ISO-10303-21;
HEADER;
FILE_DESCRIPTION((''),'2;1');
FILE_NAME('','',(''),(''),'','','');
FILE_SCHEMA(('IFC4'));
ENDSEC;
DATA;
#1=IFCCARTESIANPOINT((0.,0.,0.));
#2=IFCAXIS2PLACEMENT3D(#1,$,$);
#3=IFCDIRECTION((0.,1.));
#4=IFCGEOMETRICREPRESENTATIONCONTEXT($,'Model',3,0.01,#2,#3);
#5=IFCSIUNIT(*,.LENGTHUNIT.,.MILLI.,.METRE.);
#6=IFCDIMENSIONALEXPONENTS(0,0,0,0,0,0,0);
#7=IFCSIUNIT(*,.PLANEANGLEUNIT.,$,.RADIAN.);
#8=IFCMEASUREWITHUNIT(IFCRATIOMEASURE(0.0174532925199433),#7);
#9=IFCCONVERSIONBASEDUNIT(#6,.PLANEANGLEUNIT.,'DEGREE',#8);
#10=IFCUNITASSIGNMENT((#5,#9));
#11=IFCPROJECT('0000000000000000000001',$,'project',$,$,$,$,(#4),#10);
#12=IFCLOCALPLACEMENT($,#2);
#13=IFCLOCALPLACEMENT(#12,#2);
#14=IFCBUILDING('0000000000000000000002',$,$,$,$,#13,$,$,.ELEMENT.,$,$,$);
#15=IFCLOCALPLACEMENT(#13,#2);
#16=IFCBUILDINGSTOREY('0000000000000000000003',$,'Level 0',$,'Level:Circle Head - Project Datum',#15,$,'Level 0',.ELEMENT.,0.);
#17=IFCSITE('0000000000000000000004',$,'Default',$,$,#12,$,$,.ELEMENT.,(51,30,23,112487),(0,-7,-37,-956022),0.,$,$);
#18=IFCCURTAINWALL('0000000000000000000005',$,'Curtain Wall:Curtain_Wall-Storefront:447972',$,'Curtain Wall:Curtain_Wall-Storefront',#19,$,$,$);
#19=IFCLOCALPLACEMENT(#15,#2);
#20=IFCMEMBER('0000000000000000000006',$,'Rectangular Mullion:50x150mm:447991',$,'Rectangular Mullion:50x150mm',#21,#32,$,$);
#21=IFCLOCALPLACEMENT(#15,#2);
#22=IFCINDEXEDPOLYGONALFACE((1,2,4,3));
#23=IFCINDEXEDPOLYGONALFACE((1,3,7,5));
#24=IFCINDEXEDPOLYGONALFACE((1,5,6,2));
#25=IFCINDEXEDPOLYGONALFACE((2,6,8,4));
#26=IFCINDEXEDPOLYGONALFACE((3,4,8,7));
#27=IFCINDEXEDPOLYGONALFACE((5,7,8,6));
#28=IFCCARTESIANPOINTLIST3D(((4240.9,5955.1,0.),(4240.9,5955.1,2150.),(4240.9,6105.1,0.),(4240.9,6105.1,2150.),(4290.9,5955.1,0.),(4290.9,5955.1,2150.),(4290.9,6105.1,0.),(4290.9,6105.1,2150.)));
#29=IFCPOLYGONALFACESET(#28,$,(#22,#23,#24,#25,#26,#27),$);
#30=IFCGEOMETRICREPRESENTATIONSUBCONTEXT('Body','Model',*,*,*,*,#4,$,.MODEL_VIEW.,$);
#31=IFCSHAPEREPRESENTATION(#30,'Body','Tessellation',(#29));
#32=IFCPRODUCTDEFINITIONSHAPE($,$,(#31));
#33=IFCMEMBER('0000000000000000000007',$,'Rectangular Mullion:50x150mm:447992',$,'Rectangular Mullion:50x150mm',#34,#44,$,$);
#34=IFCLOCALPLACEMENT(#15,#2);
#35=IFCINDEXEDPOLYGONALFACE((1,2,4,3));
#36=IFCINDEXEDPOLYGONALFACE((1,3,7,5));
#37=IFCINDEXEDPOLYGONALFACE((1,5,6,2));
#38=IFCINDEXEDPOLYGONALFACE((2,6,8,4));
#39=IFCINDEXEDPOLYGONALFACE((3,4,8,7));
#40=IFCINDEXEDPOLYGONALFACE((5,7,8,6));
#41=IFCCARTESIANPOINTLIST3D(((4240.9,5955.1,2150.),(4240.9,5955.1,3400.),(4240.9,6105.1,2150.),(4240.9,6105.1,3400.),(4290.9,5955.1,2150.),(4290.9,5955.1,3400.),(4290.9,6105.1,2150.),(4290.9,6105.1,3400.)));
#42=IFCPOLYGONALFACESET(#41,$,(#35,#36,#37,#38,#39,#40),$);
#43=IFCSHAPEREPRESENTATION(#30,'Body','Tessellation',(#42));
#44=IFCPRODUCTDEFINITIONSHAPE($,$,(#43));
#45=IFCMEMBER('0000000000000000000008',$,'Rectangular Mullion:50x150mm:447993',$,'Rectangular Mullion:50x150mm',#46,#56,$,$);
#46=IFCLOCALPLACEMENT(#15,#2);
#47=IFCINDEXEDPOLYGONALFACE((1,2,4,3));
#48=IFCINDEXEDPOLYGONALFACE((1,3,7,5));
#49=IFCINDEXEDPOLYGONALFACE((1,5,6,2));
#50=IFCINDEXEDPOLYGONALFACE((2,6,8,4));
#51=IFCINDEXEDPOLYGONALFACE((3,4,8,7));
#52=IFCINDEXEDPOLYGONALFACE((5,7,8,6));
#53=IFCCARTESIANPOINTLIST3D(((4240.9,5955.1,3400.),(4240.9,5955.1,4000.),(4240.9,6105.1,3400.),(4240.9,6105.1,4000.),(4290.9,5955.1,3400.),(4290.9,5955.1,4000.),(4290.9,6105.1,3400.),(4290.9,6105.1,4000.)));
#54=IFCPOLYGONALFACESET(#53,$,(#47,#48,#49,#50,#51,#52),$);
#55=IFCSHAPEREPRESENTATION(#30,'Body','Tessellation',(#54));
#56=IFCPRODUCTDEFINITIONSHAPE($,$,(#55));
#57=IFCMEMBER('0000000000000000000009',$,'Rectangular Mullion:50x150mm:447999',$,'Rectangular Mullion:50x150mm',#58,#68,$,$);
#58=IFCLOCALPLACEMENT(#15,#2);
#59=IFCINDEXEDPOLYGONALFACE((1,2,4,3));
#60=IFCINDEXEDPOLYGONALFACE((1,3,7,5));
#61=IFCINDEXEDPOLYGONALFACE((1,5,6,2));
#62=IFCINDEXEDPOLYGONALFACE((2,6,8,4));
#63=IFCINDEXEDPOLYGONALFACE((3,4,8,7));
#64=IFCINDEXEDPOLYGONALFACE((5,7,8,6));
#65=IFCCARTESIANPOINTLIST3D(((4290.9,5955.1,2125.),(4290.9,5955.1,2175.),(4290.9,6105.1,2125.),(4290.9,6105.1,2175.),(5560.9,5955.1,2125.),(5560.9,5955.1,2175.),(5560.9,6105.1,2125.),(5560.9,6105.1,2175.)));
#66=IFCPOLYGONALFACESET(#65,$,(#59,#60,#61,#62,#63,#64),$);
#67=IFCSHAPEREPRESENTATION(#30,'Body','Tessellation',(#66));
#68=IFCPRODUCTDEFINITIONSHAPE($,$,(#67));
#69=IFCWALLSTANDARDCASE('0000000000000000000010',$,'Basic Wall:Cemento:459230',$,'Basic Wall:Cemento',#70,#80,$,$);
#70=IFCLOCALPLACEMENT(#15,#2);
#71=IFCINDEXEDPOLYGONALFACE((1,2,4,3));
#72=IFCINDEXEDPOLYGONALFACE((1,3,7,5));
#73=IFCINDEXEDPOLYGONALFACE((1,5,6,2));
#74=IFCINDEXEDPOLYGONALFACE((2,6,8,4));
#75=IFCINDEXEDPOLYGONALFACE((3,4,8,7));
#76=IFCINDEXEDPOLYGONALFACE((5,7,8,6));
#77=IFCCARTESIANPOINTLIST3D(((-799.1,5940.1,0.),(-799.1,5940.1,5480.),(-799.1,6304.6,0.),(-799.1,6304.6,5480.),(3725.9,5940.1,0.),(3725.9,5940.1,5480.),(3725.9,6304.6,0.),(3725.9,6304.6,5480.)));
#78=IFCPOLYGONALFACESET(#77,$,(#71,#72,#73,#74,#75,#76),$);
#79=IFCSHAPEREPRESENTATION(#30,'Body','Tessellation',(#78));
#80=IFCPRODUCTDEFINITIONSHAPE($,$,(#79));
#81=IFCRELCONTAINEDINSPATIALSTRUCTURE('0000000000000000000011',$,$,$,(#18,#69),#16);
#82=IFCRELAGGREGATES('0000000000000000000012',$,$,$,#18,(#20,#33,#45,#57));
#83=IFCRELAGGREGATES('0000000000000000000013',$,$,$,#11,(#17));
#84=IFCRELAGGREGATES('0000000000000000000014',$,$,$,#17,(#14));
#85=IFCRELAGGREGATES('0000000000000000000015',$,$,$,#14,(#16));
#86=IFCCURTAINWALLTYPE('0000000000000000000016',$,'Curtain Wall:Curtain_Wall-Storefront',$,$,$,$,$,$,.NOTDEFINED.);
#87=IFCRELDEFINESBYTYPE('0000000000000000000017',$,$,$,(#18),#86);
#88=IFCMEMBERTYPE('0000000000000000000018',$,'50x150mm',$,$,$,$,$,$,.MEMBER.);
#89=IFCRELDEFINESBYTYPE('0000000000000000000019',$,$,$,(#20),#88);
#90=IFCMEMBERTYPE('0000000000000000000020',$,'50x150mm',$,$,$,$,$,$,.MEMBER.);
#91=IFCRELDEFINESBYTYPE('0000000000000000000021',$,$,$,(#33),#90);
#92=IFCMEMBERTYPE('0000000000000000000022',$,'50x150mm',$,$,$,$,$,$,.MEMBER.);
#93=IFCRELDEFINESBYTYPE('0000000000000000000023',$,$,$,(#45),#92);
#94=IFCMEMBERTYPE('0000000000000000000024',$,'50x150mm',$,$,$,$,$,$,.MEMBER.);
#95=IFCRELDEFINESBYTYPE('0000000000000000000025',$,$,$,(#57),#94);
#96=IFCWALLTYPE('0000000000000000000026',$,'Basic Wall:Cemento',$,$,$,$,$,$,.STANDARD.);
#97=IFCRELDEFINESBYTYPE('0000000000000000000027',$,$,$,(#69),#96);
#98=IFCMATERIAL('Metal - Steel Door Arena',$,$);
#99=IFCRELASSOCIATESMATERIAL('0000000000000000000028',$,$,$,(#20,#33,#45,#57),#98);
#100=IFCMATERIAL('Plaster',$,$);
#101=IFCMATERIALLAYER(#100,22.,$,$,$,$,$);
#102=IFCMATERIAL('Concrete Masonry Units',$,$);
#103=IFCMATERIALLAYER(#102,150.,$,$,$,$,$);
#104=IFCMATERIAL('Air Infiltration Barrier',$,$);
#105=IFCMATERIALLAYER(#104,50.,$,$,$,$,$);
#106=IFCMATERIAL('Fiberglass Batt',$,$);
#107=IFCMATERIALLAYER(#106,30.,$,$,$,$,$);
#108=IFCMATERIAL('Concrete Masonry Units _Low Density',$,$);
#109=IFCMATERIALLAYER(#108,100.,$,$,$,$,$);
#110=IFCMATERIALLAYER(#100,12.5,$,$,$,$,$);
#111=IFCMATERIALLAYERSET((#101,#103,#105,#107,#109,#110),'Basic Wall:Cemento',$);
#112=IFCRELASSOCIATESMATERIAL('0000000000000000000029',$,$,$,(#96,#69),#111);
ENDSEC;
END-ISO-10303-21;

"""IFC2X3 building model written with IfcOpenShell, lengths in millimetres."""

from ifc_helpers import new_model, entity, si_unit, converted_unit, direction, frame, frame_2d, origin, origin_2d_with_axis, place, context, subcontext, project, spatial, rectangle, extrude, source, transform, mapped, material, layer, layer_set, layer_usage, type_object, type_shapes, element, aggregate, save


model = new_model("IFC2X3")

# Units and contexts
model_context = context("Model", 3, precision=0.01, world=origin(), true_north=direction((0.0, 1.0)))
body_context = subcontext(model_context, "Body", "Model", "MODEL_VIEW")
ifc_project = project(units=[si_unit("LENGTHUNIT", "METRE", prefix="MILLI"), converted_unit("PLANEANGLEUNIT", "DEGREE", entity("IfcRatioMeasure", 0.0174532925199433), si_unit("PLANEANGLEUNIT", "RADIAN"), dimensions=[0, 0, 0, 0, 0, 0, 0])], contexts=[model_context])

# Site, building, storey
site_placement = place(None, origin())
site = spatial("IfcSite", under=ifc_project, at=site_placement, Name="Default", CompositionType="ELEMENT", RefLatitude=(51, 30, 23, 112487), RefLongitude=(0, -7, -37, -956022), RefElevation=0.0)
building_placement = place(site_placement, origin())
building = spatial("IfcBuilding", under=site, at=building_placement, CompositionType="ELEMENT")
storey_placement = place(building_placement, origin())
storey = spatial("IfcBuildingStorey", under=building, at=storey_placement, Name="Level 0", ObjectType="Level:Circle Head - Project Datum", LongName="Level 0", CompositionType="ELEMENT", Elevation=0.0)

# Shared definitions
ifc_material_1 = material(Name="Plaster")

# Curtain wall, members
curtain_wall_type = type_object("IfcCurtainWallType", Name="Curtain Wall:Curtain_Wall-Storefront", PredefinedType="NOTDEFINED")
curtain_wall_placement = place(storey_placement, origin())
curtain_wall = element("IfcCurtainWall", 1, at=curtain_wall_placement, inside=storey, type_object=curtain_wall_type, Name="Curtain Wall:Curtain_Wall-Storefront:447972", ObjectType="Curtain Wall:Curtain_Wall-Storefront")
ifc_material_2 = material(Name="Metal - Steel Door Arena")
member_type_1 = type_object("IfcMemberType", Name="50x150mm", PredefinedType="MEMBER")
shared_shape_1 = source(origin(), body_context, "Body", "SweptSolid", [
    extrude(rectangle(XDim=150.0, YDim=50.0, at=origin_2d_with_axis()), frame((-25.0, 0.0, -2150.0), z_axis=(0.0, 0.0, 1.0), x_axis=(0.0, -1.0, 0.0)), (0.0, 0.0, 1.0), 2150.0),
])
type_shapes(member_type_1, [shared_shape_1])
member_1_placement = place(storey_placement, frame((4240.9, 6030.1, 0.0), z_axis=(0.0, 0.0, -1.0), x_axis=(-1.0, 0.0, 0.0)))
member_1 = element("IfcMember", 2, at=member_1_placement, type_object=member_type_1, material=ifc_material_2, Name="Rectangular Mullion:50x150mm:447991", ObjectType="Rectangular Mullion:50x150mm", context=body_context, shape_type="MappedRepresentation", body=[
    mapped(shared_shape_1, transform((0.0, 0.0, 0.0), scale=1.0)),
])
member_type_2 = type_object("IfcMemberType", Name="50x150mm", PredefinedType="MEMBER")
shared_shape_2 = source(origin(), body_context, "Body", "SweptSolid", [
    extrude(rectangle(XDim=150.0, YDim=50.0, at=origin_2d_with_axis()), frame((-25.0, 0.0, -1250.0), z_axis=(0.0, 0.0, 1.0), x_axis=(0.0, -1.0, 0.0)), (0.0, 0.0, 1.0), 1250.0),
])
type_shapes(member_type_2, [shared_shape_2])
member_2_placement = place(storey_placement, frame((4240.9, 6030.1, 2150.0), z_axis=(0.0, 0.0, -1.0), x_axis=(-1.0, 0.0, 0.0)))
member_2 = element("IfcMember", 3, at=member_2_placement, type_object=member_type_2, material=ifc_material_2, Name="Rectangular Mullion:50x150mm:447992", ObjectType="Rectangular Mullion:50x150mm", context=body_context, shape_type="MappedRepresentation", body=[
    mapped(shared_shape_2, transform((0.0, 0.0, 0.0), scale=1.0)),
])
member_type_3 = type_object("IfcMemberType", Name="50x150mm", PredefinedType="MEMBER")
shared_shape_3 = source(origin(), body_context, "Body", "SweptSolid", [
    extrude(rectangle(XDim=150.0, YDim=50.0, at=origin_2d_with_axis()), frame((-25.0, 0.0, -600.0), z_axis=(0.0, 0.0, 1.0), x_axis=(0.0, -1.0, 0.0)), (0.0, 0.0, 1.0), 600.0),
])
type_shapes(member_type_3, [shared_shape_3])
member_3_placement = place(storey_placement, frame((4240.9, 6030.1, 3400.0), z_axis=(0.0, 0.0, -1.0), x_axis=(-1.0, 0.0, 0.0)))
member_3 = element("IfcMember", 4, at=member_3_placement, type_object=member_type_3, material=ifc_material_2, Name="Rectangular Mullion:50x150mm:447993", ObjectType="Rectangular Mullion:50x150mm", context=body_context, shape_type="MappedRepresentation", body=[
    mapped(shared_shape_3, transform((0.0, 0.0, 0.0), scale=1.0)),
])
member_type_4 = type_object("IfcMemberType", Name="50x150mm", PredefinedType="MEMBER")
shared_shape_4 = source(origin(), body_context, "Body", "SweptSolid", [
    extrude(rectangle(XDim=150.0, YDim=50.0, at=origin_2d_with_axis()), frame((0.0, 0.0, -1270.0), z_axis=(0.0, 0.0, 1.0), x_axis=(0.0, -1.0, 0.0)), (0.0, 0.0, 1.0), 1270.0),
])
type_shapes(member_type_4, [shared_shape_4])
member_4_placement = place(storey_placement, frame((4290.9, 6030.1, 2150.0), z_axis=(-1.0, 0.0, 0.0), x_axis=(0.0, 0.0, 1.0)))
member_4 = element("IfcMember", 5, at=member_4_placement, type_object=member_type_4, material=ifc_material_2, Name="Rectangular Mullion:50x150mm:447999", ObjectType="Rectangular Mullion:50x150mm", context=body_context, shape_type="MappedRepresentation", body=[
    mapped(shared_shape_4, transform((0.0, 0.0, 0.0), scale=1.0)),
])
aggregate(curtain_wall, [member_1, member_2, member_3, member_4])

# Wall
ifc_layer_1 = layer(ifc_material_1, 22.0)
ifc_material_3 = material(Name="Concrete Masonry Units")
ifc_layer_2 = layer(ifc_material_3, 150.0)
ifc_material_4 = material(Name="Air Infiltration Barrier")
ifc_layer_3 = layer(ifc_material_4, 50.0)
ifc_material_5 = material(Name="Fiberglass Batt")
ifc_layer_4 = layer(ifc_material_5, 30.0)
ifc_material_6 = material(Name="Concrete Masonry Units _Low Density")
ifc_layer_5 = layer(ifc_material_6, 100.0)
ifc_layer_6 = layer(ifc_material_1, 12.5)
ifc_layer_set = layer_set([ifc_layer_1, ifc_layer_2, ifc_layer_3, ifc_layer_4, ifc_layer_5, ifc_layer_6], Name="Basic Wall:Cemento")
ifc_layer_usage = layer_usage(ifc_layer_set, "AXIS2", "NEGATIVE", 182.2)
wall_type = type_object("IfcWallType", Name="Basic Wall:Cemento", PredefinedType="STANDARD", material=ifc_layer_set)
wall_placement = place(storey_placement, frame((3725.9, 6122.4, 0.0), z_axis=(0.0, 0.0, 1.0), x_axis=(-1.0, 0.0, 0.0)))
element("IfcWallStandardCase", 6, at=wall_placement, inside=storey, type_object=wall_type, material=ifc_layer_usage, Name="Basic Wall:Cemento:459230", ObjectType="Basic Wall:Cemento", context=body_context, shape_type="SweptSolid", body=[
    extrude(rectangle(XDim=4525.0, YDim=364.5, at=frame_2d((2262.5, 0.0), x_axis=(-1.0, 0.0))), origin(), (0.0, 0.0, 1.0), 5480.0),
])

save(model, "model.ifc")
